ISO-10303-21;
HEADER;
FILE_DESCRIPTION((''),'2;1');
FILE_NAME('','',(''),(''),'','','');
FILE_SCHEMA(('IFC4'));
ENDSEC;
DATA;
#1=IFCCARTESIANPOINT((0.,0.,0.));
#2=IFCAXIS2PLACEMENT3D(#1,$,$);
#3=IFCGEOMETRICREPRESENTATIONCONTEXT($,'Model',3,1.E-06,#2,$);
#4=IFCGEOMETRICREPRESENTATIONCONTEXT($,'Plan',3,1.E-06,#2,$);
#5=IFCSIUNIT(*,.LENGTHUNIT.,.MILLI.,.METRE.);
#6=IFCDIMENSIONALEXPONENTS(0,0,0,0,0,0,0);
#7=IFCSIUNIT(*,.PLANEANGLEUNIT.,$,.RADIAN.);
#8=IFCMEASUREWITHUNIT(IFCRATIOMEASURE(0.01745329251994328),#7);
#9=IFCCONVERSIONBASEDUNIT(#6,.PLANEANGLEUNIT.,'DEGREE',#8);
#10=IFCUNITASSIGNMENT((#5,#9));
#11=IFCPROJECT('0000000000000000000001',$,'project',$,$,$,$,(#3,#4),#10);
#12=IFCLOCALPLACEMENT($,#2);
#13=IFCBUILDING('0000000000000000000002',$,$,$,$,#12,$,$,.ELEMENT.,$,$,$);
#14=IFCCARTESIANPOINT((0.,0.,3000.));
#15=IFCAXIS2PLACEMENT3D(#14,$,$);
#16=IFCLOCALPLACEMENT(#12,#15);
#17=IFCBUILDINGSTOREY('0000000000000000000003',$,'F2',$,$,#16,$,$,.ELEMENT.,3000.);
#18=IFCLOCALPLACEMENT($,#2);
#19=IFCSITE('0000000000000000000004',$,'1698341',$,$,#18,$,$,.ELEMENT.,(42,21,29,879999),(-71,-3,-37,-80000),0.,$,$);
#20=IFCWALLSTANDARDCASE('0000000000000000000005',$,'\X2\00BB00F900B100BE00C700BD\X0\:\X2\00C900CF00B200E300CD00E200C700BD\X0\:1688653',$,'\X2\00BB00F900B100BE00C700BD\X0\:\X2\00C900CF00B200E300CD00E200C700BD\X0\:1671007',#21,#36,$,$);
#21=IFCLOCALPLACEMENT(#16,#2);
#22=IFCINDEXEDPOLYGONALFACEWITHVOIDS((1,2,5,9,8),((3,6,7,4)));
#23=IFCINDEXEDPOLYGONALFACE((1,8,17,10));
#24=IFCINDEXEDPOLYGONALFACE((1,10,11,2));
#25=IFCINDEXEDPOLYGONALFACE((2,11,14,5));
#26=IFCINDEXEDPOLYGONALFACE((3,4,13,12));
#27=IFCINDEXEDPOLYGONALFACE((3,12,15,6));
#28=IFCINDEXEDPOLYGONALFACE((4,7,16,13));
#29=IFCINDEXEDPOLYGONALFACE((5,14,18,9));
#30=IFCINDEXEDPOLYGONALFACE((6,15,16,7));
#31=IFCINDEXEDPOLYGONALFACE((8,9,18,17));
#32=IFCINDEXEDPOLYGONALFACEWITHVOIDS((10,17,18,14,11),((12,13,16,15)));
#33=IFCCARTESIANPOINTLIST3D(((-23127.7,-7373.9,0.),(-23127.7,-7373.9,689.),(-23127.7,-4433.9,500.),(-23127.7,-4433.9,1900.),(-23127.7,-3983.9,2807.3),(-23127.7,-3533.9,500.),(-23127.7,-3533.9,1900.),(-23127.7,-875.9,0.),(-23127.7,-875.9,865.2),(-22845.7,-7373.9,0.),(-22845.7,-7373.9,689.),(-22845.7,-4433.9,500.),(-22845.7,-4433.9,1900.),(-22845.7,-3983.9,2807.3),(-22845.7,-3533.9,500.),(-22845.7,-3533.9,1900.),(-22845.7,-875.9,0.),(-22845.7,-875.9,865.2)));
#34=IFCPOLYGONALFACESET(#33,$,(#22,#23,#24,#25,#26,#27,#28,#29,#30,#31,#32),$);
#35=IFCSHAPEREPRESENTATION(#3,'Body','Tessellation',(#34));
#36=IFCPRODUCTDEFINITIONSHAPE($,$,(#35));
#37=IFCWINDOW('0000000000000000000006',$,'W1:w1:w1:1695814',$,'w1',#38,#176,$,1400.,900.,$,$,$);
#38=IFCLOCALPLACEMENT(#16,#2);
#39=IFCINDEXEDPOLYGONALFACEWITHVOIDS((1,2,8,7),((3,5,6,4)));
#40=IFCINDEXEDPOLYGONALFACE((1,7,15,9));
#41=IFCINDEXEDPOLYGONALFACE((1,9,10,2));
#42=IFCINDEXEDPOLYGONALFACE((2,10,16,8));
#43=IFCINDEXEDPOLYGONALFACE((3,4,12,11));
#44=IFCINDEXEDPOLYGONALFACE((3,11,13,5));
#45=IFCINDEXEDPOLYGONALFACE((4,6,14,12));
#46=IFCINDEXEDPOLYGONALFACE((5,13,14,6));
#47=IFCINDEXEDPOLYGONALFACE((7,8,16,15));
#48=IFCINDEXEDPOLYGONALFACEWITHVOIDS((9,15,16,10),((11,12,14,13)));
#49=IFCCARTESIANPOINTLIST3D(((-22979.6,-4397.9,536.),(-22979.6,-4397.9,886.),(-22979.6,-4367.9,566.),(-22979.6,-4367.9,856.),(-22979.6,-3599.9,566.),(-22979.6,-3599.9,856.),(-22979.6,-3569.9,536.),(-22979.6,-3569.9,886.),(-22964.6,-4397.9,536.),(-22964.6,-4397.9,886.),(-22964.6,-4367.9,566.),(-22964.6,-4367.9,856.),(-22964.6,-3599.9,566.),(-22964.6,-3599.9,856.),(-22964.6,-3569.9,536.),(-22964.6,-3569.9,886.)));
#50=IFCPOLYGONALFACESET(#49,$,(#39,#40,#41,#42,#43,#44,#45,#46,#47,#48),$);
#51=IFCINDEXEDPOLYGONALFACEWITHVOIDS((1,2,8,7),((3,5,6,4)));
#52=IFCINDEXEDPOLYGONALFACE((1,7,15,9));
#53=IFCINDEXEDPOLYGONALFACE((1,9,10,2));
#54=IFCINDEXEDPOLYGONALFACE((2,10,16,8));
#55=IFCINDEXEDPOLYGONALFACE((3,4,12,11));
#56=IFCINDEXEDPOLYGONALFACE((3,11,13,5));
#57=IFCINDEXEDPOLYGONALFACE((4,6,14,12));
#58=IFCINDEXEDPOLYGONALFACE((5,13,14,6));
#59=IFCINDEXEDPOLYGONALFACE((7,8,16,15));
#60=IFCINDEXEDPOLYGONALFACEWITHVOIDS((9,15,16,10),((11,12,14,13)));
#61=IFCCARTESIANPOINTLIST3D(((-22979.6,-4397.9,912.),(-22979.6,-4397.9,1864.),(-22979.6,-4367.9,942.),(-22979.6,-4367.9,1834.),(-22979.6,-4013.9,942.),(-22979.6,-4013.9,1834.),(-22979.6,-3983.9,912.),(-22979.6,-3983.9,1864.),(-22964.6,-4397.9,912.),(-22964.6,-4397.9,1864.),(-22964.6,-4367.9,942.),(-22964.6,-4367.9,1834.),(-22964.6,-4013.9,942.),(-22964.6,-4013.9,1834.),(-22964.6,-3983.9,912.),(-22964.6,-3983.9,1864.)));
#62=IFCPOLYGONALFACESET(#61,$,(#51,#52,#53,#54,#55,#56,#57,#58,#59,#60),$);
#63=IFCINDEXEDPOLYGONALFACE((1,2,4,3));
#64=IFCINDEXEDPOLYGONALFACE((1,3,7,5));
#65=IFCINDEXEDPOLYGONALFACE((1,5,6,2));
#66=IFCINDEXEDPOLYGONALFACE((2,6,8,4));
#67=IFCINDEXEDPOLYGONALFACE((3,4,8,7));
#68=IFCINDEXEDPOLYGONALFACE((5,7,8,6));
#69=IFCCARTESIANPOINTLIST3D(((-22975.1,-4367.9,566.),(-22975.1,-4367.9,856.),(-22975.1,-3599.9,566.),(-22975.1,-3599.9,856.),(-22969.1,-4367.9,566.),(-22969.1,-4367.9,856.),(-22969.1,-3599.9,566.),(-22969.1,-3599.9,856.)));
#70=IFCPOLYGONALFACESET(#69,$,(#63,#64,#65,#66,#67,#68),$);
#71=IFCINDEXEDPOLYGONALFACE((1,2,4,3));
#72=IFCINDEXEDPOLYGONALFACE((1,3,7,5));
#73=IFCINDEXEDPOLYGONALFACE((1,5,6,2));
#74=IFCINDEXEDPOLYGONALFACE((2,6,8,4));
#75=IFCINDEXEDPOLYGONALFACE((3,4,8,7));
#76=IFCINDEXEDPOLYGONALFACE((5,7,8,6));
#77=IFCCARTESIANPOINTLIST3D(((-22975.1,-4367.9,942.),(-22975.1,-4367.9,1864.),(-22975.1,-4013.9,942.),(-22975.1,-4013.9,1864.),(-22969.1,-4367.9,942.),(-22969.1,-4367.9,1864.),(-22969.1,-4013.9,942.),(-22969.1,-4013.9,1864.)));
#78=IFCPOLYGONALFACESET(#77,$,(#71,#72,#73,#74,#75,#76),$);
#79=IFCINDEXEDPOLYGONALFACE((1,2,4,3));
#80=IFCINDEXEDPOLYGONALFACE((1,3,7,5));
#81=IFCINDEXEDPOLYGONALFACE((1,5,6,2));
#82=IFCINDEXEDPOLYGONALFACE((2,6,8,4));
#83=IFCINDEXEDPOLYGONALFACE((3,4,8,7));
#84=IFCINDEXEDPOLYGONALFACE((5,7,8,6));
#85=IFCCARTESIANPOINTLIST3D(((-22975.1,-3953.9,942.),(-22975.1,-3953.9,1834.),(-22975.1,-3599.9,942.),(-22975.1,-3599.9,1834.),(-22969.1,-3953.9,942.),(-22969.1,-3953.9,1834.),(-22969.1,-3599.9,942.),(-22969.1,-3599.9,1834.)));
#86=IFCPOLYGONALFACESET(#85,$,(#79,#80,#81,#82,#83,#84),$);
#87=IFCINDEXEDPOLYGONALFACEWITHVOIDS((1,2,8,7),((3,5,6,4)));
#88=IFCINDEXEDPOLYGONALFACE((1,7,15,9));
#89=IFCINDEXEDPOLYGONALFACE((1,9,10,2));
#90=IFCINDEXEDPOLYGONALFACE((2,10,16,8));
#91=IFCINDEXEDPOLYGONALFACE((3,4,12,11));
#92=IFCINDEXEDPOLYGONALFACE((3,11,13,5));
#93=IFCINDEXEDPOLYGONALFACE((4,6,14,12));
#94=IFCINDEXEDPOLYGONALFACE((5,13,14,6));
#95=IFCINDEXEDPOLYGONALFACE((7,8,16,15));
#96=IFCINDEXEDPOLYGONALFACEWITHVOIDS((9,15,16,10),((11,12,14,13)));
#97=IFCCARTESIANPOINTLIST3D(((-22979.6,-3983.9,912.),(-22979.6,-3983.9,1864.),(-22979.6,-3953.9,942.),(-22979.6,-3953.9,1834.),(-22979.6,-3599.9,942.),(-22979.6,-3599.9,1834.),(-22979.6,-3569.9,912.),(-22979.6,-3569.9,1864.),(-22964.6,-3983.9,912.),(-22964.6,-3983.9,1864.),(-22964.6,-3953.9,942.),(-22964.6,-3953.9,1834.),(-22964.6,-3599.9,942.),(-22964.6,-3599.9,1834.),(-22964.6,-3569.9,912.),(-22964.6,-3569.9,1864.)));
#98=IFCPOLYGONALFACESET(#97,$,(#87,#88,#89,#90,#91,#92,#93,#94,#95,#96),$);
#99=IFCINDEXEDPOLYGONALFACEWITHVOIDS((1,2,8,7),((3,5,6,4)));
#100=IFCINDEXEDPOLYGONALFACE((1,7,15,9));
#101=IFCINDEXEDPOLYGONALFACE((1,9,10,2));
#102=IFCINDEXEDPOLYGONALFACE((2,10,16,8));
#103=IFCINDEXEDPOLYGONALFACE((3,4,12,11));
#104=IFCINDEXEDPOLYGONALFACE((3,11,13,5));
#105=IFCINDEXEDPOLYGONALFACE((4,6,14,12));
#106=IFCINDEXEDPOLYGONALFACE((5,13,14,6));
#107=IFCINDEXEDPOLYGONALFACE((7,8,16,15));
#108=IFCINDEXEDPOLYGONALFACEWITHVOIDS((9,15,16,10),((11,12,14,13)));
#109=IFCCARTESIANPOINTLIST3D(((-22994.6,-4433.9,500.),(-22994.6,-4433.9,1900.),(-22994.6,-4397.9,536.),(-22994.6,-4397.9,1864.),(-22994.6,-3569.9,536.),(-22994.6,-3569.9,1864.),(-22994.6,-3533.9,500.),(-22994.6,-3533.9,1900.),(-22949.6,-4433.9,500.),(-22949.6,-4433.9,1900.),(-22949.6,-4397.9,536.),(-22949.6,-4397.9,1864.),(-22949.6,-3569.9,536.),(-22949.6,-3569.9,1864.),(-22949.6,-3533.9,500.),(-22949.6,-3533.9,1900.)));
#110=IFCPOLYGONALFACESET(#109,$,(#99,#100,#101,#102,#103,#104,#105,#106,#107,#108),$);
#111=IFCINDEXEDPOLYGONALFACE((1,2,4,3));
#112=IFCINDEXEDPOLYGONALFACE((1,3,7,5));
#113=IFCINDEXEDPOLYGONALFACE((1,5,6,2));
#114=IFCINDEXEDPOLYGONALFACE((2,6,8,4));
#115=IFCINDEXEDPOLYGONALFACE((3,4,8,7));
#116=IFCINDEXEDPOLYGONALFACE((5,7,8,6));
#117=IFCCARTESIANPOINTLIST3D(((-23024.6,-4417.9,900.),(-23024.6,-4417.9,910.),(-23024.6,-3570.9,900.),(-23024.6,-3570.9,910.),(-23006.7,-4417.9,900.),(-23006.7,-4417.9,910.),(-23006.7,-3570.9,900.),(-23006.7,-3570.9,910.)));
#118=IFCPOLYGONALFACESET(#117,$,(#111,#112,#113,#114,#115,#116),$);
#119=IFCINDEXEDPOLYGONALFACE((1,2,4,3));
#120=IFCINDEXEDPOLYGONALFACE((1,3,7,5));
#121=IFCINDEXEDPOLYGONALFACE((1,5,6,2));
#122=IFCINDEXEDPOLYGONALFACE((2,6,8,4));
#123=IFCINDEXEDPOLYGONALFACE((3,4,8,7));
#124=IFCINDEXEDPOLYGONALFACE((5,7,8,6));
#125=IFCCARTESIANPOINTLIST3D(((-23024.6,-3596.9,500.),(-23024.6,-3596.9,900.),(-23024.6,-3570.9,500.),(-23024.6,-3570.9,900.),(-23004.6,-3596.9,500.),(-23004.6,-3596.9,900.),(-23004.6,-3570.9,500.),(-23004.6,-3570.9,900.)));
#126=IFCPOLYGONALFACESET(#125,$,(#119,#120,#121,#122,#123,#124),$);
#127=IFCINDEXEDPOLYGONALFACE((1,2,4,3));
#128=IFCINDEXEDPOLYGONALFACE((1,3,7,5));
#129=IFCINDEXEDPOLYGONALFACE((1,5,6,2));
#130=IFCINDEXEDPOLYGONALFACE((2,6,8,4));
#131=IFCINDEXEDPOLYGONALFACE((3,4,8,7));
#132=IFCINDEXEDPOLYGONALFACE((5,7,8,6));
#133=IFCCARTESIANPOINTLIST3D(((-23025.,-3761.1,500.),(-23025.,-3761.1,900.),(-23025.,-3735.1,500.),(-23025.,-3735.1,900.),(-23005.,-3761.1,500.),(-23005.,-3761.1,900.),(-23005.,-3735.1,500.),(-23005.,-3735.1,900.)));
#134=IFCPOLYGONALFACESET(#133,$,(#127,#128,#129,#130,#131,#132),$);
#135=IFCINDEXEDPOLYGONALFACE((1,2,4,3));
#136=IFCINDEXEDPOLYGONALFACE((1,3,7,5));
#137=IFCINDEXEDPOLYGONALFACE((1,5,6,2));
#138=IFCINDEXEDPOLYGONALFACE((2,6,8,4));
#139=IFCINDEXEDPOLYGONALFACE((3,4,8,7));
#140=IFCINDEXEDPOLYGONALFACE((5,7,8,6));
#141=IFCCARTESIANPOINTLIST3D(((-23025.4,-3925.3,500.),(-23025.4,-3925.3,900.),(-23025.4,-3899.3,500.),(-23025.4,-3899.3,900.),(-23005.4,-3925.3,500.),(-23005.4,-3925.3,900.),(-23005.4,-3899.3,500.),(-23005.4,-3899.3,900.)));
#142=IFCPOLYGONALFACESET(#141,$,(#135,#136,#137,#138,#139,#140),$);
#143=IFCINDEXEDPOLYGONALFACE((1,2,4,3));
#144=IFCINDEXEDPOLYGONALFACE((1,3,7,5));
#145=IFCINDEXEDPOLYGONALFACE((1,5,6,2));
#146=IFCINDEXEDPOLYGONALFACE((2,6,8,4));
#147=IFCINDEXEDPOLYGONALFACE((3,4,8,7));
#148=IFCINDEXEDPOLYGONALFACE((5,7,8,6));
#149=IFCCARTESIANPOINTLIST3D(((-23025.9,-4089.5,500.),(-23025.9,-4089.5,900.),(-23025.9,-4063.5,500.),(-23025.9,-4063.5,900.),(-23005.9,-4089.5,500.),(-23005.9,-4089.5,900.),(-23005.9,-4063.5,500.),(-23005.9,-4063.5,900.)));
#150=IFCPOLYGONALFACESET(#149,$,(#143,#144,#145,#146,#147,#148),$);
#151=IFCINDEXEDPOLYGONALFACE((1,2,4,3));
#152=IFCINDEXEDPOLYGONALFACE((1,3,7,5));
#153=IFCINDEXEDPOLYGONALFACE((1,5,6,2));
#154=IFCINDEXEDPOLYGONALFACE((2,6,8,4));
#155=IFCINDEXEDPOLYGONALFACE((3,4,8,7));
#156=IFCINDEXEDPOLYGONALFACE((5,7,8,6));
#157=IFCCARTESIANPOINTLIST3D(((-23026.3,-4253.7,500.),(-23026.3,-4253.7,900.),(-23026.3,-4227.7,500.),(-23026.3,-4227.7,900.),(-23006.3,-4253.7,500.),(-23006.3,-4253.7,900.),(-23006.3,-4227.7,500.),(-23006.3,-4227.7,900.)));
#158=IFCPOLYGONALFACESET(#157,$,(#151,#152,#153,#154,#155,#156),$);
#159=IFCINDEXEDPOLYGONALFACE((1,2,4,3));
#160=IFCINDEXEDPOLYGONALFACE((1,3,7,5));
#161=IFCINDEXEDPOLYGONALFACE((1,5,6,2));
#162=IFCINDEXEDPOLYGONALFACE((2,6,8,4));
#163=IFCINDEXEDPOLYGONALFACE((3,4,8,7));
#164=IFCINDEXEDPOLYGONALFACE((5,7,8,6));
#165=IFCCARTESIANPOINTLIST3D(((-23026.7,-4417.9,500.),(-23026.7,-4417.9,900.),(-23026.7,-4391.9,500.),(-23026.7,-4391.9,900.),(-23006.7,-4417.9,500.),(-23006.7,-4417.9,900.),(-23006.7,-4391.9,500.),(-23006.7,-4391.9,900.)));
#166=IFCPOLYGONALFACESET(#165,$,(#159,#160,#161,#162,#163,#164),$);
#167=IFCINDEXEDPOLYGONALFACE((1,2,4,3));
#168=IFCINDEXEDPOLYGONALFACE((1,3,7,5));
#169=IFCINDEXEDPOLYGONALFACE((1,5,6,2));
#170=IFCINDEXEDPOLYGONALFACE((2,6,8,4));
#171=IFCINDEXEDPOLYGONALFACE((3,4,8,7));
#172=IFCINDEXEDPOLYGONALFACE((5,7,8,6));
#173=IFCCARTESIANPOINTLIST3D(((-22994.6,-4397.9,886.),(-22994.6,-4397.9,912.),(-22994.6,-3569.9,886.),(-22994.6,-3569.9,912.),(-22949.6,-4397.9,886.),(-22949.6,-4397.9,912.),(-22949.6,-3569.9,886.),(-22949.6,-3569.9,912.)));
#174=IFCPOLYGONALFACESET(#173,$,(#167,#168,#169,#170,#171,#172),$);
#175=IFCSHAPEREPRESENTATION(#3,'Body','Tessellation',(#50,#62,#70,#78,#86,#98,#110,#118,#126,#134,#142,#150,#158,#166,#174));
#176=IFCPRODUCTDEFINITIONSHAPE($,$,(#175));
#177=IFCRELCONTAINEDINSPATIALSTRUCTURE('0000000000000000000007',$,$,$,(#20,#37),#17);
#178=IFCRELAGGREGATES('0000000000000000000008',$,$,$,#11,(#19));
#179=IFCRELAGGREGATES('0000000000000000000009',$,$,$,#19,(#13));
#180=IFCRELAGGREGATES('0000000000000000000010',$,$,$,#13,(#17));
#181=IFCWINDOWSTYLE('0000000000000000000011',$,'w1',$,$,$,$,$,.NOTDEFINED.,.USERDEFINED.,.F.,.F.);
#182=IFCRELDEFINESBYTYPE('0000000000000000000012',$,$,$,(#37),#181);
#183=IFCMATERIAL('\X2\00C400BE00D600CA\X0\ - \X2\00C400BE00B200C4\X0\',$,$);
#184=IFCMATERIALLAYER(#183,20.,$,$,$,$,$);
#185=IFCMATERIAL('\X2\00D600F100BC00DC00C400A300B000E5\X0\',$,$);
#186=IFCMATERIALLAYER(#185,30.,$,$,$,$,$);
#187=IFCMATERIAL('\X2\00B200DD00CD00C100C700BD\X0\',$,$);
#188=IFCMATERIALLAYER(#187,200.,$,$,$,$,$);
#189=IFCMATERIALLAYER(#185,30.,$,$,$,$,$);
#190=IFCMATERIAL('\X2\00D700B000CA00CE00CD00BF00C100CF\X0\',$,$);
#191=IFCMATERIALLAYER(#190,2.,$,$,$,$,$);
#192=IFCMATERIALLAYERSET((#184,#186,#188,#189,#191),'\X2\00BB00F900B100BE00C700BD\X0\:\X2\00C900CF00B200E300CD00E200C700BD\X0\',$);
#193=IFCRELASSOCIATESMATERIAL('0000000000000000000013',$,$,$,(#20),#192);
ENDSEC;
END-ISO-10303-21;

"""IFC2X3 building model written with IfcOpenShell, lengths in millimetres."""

from ifc_helpers import new_model, entity, si_unit, converted_unit, frame, frame_2d, origin, origin_2d_with_axis, place, context, project, spatial, polyline, rectangle, outline, extrude, clip, bounded_halfspace, source, transform, mapped, material, layer, layer_set, layer_usage, type_object, type_shapes, element, fill, save


model = new_model("IFC2X3")

# Units and contexts
model_context = context("Model", 3, precision=1e-06, world=origin())
plan_context = context("Plan", 3, precision=1e-06, world=origin())
ifc_project = project(units=[si_unit("LENGTHUNIT", "METRE", prefix="MILLI"), converted_unit("PLANEANGLEUNIT", "DEGREE", entity("IfcRatioMeasure", 0.01745329251994328), si_unit("PLANEANGLEUNIT", "RADIAN"), dimensions=[0, 0, 0, 0, 0, 0, 0])], contexts=[model_context, plan_context])

# Site, building, storey
site_placement = place(None, origin())
site = spatial("IfcSite", under=ifc_project, at=site_placement, Name="1698341", CompositionType="ELEMENT", RefLatitude=(42, 21, 29, 879999), RefLongitude=(-71, -3, -37, -80000), RefElevation=0.0)
building_placement = place(None, origin())
building = spatial("IfcBuilding", under=site, at=building_placement, CompositionType="ELEMENT")
storey_placement = place(building_placement, frame((0.0, 0.0, 3000.0)))
storey = spatial("IfcBuildingStorey", under=building, at=storey_placement, Name="F2", CompositionType="ELEMENT", Elevation=3000.0)

# Shared definitions
ifc_material_1 = material(Name="Öñ¼ÜÄ£°å")

# Shared definitions
ifc_material_2 = material(Name="Ä¾ÖÊ - Ä¾²Ä")
ifc_layer_1 = layer(ifc_material_2, 20.0)
ifc_layer_2 = layer(ifc_material_1, 30.0)
ifc_material_3 = material(Name="²ÝÍÁÇ½")
ifc_layer_3 = layer(ifc_material_3, 200.0)
ifc_layer_4 = layer(ifc_material_1, 30.0)
ifc_material_4 = material(Name="×°ÊÎÍ¿ÁÏ")
ifc_layer_5 = layer(ifc_material_4, 2.0)
ifc_layer_set_1 = layer_set([ifc_layer_1, ifc_layer_2, ifc_layer_3, ifc_layer_4, ifc_layer_5], Name="»ù±¾Ç½:ÉÏ²ãÍâÇ½")

# Wall, opening, window
ifc_layer_usage_1 = layer_usage(ifc_layer_set_1, "AXIS2", "NEGATIVE", 141.0)
wall_1_placement = place(storey_placement, frame((-22986.7, -875.9, 0.0), z_axis=(0.0, 0.0, 1.0), x_axis=(0.0, -1.0, 0.0)))
wall_1 = element("IfcWallStandardCase", 1, at=wall_1_placement, inside=storey, material=ifc_layer_usage_1, Name="»ù±¾Ç½:ÉÏ²ãÍâÇ½:1688653", ObjectType="»ù±¾Ç½:ÉÏ²ãÍâÇ½:1671007", context=model_context, shape_type="Clipping", body=[
    clip(clip(extrude(rectangle(XDim=6498.0, YDim=282.0, at=frame_2d((3249.0, 0.0), x_axis=(-1.0, 0.0))), origin(), (0.0, 0.0, 1.0), 3200.0), bounded_halfspace(frame((0.0, -141.0, 865.2), z_axis=(-0.529919, 0.0, 0.848048), x_axis=(0.0, -1.0, 0.0)), False, frame((0.0, -141.0, 865.2)), polyline([(0.0, 0.0), (3108.0, 0.0), (3108.0, 282.0), (0.0, 282.0), (0.0, 0.0)]))), bounded_halfspace(frame((3108.0, -141.0, 2807.3), z_axis=(0.529919, 0.0, 0.848048), x_axis=(0.0, 1.0, 0.0)), False, frame((3108.0, -141.0, 2807.3)), polyline([(0.0, 0.0), (3390.0, 0.0), (3390.0, 282.0), (0.0, 282.0), (0.0, 0.0)]))),
])
opening_1_placement = place(wall_1_placement, frame((2658.0, -141.0, 500.0)))
opening_1 = element("IfcOpeningElement", 2, at=opening_1_placement, cuts=wall_1, ObjectType="Opening", context=model_context, shape_type="SweptSolid", body=[
    extrude(rectangle(XDim=1400.0, YDim=900.0, at=frame_2d((700.0, 450.0), x_axis=(-1.0, 0.0))), frame((0.0, 0.0, 0.0), z_axis=(0.0, 1.0, 0.0), x_axis=(0.0, 0.0, 1.0)), (0.0, 0.0, 1.0), 282.0),
])
window_style_1 = type_object("IfcWindowStyle", Name="w1", ConstructionType="NOTDEFINED", OperationType="USERDEFINED", ParameterTakesPrecedence=False, Sizeable=False)
shared_shape_1 = source(origin(), model_context, "Body", "SweptSolid", [
    extrude(outline(polyline([(-414.0, -175.0), (414.0, -175.0), (414.0, 175.0), (-414.0, 175.0), (-414.0, -175.0)]), holes=[polyline([(-384.0, 145.0), (384.0, 145.0), (384.0, -145.0), (-384.0, -145.0), (-384.0, 145.0)])]), frame((-202.3, 158.8, 211.0), z_axis=(0.0, -1.0, 0.0), x_axis=(-1.0, 0.0, 0.0)), (0.0, 0.0, 1.0), 15.0),
    extrude(outline(polyline([(-207.0, -476.0), (207.0, -476.0), (207.0, 476.0), (-207.0, 476.0), (-207.0, -476.0)]), holes=[polyline([(-177.0, 446.0), (177.0, 446.0), (177.0, -446.0), (-177.0, -446.0), (-177.0, 446.0)])]), frame((4.7, 158.8, 888.0), z_axis=(0.0, -1.0, 0.0), x_axis=(-1.0, 0.0, 0.0)), (0.0, 0.0, 1.0), 15.0),
    extrude(rectangle(XDim=768.0, YDim=6.0, at=origin_2d_with_axis()), frame((-202.3, 151.3, 66.0)), (0.0, 0.0, 1.0), 290.0),
    extrude(rectangle(XDim=354.0, YDim=6.0, at=origin_2d_with_axis()), frame((4.7, 151.3, 442.0)), (0.0, 0.0, 1.0), 922.0),
    extrude(rectangle(XDim=354.0, YDim=6.0, at=origin_2d_with_axis()), frame((-409.3, 151.3, 442.0)), (0.0, 0.0, 1.0), 892.0),
    extrude(outline(polyline([(-207.0, -476.0), (207.0, -476.0), (207.0, 476.0), (-207.0, 476.0), (-207.0, -476.0)]), holes=[polyline([(-177.0, 446.0), (177.0, 446.0), (177.0, -446.0), (-177.0, -446.0), (-177.0, 446.0)])]), frame((-409.3, 158.8, 888.0), z_axis=(0.0, -1.0, 0.0), x_axis=(-1.0, 0.0, 0.0)), (0.0, 0.0, 1.0), 15.0),
    extrude(outline(polyline([(-450.0, -700.0), (450.0, -700.0), (450.0, 700.0), (-450.0, 700.0), (-450.0, -700.0)]), holes=[polyline([(-414.0, 664.0), (414.0, 664.0), (414.0, -664.0), (-414.0, -664.0), (-414.0, 664.0)])]), frame((-202.3, 173.9, 700.0), z_axis=(0.0, -1.0, 0.0), x_axis=(-1.0, 0.0, 0.0)), (0.0, 0.0, 1.0), 45.0),
    extrude(rectangle(XDim=17.9, YDim=847.1, at=origin_2d_with_axis()), frame((-191.8, 107.8, 400.0), z_axis=(0.0, 0.0, 1.0), x_axis=(0.0, -1.0, 0.0)), (0.0, 0.0, 1.0), 10.0),
    extrude(rectangle(XDim=20.0, YDim=26.0, at=origin_2d_with_axis()), frame((-602.3, 108.9, 0.0), z_axis=(0.0, 0.0, 1.0), x_axis=(0.0, -1.0, 0.0)), (0.0, 0.0, 1.0), 400.0),
    extrude(rectangle(XDim=20.0, YDim=26.0, at=origin_2d_with_axis()), frame((-438.1, 108.4, 0.0), z_axis=(0.0, 0.0, 1.0), x_axis=(0.0, -1.0, 0.0)), (0.0, 0.0, 1.0), 400.0),
    extrude(rectangle(XDim=20.0, YDim=26.0, at=origin_2d_with_axis()), frame((-273.9, 108.0, 0.0), z_axis=(0.0, 0.0, 1.0), x_axis=(0.0, -1.0, 0.0)), (0.0, 0.0, 1.0), 400.0),
    extrude(rectangle(XDim=20.0, YDim=26.0, at=origin_2d_with_axis()), frame((-109.7, 107.6, 0.0), z_axis=(0.0, 0.0, 1.0), x_axis=(0.0, -1.0, 0.0)), (0.0, 0.0, 1.0), 400.0),
    extrude(rectangle(XDim=20.0, YDim=26.0, at=origin_2d_with_axis()), frame((54.5, 107.1, 0.0), z_axis=(0.0, 0.0, 1.0), x_axis=(0.0, -1.0, 0.0)), (0.0, 0.0, 1.0), 400.0),
    extrude(rectangle(XDim=20.0, YDim=26.0, at=origin_2d_with_axis()), frame((218.7, 106.7, 0.0), z_axis=(0.0, 0.0, 1.0), x_axis=(0.0, -1.0, 0.0)), (0.0, 0.0, 1.0), 400.0),
    extrude(rectangle(XDim=828.0, YDim=45.0, at=origin_2d_with_axis()), frame((-202.3, 151.3, 386.0)), (0.0, 0.0, 1.0), 26.0),
])
type_shapes(window_style_1, [shared_shape_1])
window_1_placement = place(opening_1_placement, frame((652.3, 4.3, 0.0)))
window_1 = element("IfcWindow", 3, at=window_1_placement, inside=storey, type_object=window_style_1, Name="W1:w1:w1:1695814", ObjectType="w1", OverallHeight=1400.0, OverallWidth=900.0, context=model_context, shape_type="MappedRepresentation", body=[
    mapped(shared_shape_1, transform((0.0, 0.0, 0.0), scale=1.0)),
])
fill(opening_1, window_1)

save(model, "model.ifc")
